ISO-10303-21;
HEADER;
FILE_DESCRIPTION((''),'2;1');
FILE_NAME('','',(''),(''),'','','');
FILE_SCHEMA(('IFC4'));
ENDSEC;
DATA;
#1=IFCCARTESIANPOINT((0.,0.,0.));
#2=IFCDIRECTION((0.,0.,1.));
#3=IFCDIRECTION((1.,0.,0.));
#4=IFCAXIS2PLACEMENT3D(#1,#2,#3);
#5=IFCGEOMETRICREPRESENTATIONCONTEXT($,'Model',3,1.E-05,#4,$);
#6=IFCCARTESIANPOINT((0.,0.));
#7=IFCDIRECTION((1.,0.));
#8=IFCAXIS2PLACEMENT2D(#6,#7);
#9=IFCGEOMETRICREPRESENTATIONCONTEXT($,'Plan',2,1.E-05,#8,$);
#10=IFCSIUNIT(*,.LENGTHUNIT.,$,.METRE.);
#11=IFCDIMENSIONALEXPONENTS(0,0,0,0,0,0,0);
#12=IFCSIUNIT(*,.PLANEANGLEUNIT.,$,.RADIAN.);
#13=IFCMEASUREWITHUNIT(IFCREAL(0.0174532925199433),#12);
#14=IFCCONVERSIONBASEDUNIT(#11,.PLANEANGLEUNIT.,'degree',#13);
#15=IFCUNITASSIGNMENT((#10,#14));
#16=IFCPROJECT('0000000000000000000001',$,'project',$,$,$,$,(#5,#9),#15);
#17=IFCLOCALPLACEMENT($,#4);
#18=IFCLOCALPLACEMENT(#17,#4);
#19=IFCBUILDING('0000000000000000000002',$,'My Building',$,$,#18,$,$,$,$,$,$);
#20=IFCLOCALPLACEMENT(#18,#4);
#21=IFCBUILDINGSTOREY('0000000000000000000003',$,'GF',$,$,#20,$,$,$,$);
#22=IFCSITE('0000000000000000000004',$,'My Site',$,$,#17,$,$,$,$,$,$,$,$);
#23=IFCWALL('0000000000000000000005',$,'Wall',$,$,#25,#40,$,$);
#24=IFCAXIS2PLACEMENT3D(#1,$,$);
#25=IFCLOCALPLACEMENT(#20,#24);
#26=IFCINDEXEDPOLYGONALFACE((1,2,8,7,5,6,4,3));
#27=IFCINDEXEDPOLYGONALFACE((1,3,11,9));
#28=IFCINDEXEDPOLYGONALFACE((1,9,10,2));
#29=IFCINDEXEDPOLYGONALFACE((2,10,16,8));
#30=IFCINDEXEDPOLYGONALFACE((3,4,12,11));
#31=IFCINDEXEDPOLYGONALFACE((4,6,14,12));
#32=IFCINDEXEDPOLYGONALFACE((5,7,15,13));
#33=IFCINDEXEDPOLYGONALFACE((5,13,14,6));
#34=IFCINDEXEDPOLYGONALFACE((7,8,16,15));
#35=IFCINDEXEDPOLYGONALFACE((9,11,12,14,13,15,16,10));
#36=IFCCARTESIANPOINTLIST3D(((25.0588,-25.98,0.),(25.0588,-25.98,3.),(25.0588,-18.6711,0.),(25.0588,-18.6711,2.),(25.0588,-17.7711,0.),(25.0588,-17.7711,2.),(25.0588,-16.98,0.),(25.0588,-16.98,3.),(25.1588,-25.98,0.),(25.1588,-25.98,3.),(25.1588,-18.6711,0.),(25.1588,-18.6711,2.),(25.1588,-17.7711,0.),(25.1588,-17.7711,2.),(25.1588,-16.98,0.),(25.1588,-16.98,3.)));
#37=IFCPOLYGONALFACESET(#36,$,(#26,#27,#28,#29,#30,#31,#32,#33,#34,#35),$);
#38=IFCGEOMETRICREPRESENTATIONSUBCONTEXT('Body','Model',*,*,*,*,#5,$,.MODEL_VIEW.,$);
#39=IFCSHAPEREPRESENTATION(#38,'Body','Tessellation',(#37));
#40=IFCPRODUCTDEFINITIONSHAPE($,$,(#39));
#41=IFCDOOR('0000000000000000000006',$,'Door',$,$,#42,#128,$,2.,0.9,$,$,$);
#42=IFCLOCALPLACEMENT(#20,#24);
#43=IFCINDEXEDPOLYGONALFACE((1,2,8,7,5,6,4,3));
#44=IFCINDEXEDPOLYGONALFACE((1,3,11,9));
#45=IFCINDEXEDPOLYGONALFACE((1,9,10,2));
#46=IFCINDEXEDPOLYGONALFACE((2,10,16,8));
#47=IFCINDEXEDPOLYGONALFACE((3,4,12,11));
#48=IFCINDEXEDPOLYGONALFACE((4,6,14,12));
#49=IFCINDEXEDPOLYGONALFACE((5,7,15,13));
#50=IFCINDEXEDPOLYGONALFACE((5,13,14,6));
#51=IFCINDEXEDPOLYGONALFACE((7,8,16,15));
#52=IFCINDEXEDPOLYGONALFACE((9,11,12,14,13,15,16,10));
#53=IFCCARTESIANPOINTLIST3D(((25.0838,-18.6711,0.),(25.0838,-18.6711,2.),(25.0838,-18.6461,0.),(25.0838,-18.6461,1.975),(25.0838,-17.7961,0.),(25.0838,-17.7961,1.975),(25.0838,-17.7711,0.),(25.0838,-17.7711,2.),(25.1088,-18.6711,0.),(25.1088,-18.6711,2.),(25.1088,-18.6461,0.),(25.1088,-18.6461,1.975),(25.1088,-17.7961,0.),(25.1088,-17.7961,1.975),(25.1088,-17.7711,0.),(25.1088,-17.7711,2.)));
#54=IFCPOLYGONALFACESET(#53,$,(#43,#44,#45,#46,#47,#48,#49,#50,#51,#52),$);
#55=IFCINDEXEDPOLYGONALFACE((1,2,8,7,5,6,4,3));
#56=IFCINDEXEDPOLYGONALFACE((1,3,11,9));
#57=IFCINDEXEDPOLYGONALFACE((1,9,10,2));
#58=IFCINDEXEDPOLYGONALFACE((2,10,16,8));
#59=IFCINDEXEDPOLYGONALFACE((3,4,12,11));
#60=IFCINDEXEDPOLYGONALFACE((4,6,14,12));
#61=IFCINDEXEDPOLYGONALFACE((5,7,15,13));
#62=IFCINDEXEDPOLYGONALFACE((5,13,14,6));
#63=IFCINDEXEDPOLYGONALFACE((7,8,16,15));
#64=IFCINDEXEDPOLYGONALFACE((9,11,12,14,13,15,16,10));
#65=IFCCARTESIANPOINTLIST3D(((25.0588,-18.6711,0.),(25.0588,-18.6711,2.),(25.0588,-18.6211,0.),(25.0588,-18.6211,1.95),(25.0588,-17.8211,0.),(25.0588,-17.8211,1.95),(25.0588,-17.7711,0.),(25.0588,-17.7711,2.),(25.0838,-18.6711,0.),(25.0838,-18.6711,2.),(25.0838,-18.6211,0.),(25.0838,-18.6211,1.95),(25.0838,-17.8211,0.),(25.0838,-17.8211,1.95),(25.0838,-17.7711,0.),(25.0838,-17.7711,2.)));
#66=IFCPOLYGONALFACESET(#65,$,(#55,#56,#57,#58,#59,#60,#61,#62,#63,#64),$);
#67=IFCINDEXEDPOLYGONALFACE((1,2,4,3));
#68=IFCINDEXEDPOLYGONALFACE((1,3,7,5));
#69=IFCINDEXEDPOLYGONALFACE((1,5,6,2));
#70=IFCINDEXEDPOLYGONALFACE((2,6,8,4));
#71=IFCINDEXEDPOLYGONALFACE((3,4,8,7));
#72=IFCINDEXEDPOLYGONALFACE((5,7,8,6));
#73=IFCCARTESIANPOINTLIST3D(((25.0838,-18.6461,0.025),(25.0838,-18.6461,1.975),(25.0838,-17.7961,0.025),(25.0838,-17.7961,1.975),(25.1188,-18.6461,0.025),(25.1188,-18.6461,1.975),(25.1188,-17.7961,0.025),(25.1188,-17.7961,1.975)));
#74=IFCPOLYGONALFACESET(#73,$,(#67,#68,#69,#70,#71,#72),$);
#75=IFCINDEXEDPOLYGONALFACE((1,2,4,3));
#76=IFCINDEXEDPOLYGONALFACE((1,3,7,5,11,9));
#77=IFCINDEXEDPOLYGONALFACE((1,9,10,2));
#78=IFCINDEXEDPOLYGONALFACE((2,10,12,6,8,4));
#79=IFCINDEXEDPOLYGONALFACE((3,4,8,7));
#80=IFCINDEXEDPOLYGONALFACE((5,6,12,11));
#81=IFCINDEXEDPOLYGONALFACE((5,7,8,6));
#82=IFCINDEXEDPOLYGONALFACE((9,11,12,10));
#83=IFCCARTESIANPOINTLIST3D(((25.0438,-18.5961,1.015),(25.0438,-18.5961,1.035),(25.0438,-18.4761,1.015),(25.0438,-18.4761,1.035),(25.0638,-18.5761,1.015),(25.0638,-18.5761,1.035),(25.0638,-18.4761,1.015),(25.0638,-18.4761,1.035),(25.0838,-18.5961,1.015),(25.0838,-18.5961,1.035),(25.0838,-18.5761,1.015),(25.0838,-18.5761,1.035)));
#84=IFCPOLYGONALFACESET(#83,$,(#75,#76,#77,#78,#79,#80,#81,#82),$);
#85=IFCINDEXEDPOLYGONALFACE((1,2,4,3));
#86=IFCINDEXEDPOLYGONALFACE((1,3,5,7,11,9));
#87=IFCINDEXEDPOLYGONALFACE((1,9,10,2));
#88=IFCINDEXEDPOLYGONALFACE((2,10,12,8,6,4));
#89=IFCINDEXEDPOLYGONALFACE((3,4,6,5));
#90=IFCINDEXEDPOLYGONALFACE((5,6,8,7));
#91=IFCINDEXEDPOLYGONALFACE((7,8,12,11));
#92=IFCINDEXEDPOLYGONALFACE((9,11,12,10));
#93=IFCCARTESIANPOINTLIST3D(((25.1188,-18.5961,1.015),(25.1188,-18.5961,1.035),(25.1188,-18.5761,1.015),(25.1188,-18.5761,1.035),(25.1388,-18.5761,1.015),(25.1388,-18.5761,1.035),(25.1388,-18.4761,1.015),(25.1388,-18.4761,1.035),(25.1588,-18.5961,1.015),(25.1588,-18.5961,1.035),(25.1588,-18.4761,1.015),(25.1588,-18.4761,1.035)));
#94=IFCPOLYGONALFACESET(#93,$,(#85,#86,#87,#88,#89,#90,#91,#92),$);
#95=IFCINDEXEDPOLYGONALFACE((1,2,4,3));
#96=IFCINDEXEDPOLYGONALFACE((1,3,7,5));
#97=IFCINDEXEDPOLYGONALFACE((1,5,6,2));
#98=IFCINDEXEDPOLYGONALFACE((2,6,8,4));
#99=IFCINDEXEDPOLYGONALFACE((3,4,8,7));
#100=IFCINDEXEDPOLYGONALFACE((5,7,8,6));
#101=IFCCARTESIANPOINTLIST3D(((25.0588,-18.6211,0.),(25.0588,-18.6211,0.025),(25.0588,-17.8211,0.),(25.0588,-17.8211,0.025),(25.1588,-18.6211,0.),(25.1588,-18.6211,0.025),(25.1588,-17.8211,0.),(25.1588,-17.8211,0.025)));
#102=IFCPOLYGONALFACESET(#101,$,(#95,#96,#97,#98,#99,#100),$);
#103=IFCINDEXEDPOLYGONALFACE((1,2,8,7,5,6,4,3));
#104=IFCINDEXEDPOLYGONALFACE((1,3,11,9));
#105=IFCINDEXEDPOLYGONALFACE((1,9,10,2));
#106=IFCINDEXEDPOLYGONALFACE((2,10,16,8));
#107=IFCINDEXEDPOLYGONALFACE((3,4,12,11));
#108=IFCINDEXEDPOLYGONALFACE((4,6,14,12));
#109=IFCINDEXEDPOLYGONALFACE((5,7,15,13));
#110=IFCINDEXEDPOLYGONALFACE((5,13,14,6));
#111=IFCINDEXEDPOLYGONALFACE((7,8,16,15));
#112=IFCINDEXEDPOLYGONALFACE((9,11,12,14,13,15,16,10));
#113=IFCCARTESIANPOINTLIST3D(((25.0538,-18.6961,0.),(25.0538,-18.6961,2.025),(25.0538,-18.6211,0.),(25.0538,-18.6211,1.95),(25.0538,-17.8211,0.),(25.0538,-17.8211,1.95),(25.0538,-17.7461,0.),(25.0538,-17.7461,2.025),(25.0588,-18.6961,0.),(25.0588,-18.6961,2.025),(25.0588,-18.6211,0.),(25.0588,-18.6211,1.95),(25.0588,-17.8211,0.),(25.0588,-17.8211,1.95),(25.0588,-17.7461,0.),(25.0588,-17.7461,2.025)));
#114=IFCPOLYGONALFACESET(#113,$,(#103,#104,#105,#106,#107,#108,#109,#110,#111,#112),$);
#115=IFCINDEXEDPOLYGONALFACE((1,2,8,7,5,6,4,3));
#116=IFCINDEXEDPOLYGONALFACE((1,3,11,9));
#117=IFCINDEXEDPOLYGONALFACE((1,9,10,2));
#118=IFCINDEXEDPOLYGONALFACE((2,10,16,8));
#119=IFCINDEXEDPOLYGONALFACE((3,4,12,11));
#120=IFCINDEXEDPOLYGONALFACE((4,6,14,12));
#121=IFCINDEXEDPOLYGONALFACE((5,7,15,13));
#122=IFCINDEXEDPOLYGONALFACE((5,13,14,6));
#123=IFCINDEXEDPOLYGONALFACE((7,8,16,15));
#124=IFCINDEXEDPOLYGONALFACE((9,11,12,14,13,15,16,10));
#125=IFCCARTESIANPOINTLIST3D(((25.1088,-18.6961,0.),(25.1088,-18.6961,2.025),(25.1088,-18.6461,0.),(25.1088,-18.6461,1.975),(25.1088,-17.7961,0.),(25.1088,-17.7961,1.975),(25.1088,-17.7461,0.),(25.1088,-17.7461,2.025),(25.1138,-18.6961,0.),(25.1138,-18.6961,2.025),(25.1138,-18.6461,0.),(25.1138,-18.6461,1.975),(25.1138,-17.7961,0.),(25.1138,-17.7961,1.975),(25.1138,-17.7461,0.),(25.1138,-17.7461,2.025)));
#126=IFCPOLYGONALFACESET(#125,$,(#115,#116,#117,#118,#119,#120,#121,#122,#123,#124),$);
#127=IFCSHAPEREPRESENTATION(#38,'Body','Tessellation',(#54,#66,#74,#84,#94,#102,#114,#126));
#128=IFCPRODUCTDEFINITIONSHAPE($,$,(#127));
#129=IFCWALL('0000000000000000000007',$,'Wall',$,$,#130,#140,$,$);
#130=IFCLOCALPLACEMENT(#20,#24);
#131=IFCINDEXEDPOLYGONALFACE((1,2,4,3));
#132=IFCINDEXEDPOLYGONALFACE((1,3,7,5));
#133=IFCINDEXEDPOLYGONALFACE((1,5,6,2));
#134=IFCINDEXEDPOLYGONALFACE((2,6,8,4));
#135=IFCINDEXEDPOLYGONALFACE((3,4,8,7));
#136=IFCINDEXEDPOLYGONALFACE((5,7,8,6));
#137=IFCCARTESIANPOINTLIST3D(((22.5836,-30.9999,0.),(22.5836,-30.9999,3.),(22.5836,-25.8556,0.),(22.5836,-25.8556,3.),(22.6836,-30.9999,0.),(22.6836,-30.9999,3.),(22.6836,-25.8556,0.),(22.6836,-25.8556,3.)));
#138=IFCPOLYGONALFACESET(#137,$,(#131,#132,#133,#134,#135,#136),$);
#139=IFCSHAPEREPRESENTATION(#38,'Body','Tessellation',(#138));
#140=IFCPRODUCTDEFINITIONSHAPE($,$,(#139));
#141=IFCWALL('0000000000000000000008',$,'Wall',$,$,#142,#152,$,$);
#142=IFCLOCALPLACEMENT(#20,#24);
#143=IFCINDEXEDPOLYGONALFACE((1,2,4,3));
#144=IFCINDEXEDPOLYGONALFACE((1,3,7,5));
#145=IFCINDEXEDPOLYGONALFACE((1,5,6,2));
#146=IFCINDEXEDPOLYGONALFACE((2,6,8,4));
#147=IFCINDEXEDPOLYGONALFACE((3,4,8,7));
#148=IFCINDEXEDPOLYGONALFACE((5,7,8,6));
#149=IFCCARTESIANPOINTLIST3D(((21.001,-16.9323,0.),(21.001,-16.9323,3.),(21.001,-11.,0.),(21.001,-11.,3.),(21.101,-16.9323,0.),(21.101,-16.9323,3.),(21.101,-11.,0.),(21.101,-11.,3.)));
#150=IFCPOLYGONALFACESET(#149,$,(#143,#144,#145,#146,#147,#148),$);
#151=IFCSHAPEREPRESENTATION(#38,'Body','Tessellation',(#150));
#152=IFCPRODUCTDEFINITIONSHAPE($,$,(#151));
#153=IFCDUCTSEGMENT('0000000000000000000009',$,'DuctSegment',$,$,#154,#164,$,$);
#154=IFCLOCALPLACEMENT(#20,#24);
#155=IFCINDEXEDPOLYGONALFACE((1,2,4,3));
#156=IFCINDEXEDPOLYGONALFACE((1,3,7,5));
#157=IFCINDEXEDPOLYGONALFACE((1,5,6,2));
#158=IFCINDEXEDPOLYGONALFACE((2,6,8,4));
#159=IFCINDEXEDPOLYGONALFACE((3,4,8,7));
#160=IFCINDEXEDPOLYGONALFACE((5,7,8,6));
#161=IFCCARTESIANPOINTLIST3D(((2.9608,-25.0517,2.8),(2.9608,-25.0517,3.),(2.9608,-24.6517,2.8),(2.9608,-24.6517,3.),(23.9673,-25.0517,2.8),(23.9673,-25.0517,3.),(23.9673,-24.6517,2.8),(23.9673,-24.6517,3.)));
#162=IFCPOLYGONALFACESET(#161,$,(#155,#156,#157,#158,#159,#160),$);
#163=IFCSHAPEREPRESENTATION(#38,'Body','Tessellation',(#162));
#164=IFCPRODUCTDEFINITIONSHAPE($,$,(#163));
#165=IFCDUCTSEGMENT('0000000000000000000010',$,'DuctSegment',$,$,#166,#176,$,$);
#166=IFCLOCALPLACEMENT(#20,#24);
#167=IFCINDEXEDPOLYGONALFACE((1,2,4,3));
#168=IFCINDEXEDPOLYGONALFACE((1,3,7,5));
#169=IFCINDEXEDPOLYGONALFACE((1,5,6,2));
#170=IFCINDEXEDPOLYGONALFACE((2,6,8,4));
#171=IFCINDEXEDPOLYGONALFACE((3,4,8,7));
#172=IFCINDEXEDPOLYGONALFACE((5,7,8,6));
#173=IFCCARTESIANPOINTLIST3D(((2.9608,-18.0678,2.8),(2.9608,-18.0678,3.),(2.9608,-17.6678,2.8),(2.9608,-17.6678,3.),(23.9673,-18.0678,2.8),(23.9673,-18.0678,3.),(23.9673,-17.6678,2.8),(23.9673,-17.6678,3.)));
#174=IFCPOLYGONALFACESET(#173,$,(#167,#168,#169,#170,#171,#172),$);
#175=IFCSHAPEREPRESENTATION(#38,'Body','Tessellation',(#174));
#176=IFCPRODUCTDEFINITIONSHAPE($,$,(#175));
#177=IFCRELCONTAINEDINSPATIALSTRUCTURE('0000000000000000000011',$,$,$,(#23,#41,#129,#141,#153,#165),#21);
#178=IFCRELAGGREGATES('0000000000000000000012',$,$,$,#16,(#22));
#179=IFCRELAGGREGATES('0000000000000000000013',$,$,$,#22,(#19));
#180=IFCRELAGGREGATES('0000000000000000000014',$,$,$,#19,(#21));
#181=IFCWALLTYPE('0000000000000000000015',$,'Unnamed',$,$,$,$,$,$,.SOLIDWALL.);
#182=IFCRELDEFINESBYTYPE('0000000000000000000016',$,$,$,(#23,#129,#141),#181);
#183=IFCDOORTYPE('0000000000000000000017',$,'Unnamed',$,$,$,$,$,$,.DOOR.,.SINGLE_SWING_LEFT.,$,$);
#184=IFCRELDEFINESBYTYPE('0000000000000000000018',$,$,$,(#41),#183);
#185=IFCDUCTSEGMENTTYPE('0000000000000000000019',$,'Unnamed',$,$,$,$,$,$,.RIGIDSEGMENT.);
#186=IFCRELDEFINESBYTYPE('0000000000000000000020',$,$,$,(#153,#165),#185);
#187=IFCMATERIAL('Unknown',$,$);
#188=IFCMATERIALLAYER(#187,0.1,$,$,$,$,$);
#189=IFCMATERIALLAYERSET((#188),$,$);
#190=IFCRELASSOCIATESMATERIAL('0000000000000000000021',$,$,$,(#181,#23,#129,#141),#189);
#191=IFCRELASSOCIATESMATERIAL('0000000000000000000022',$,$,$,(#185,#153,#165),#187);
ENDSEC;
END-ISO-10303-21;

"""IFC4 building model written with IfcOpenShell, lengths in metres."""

from ifc_helpers import new_model, entity, si_unit, converted_unit, frame, origin_with_axes, origin_2d_with_axis, place, context, subcontext, project, spatial, line, indexed_curve, rectangle, outline, extrude, shape, source, transform, mapped, material, layer, layer_set, layer_usage, material_profile, profile_set, profile_usage, type_object, type_shapes, element, fill, save


model = new_model("IFC4")

# Units and contexts
model_context = context("Model", 3, precision=1e-05, world=origin_with_axes())
plan_context = context("Plan", 2, precision=1e-05, world=origin_2d_with_axis())
body_context_1 = subcontext(model_context, "Body", "Model", "MODEL_VIEW")
body_context_2 = subcontext(plan_context, "Body", "Plan", "PLAN_VIEW")
ifc_project = project(units=[si_unit("LENGTHUNIT", "METRE"), converted_unit("PLANEANGLEUNIT", "degree", entity("IfcReal", 0.0174532925199433), si_unit("PLANEANGLEUNIT", "RADIAN"), dimensions=[0, 0, 0, 0, 0, 0, 0])], contexts=[model_context, plan_context])

# Site, building, storey
site_placement = place(None, origin_with_axes())
site = spatial("IfcSite", under=ifc_project, at=site_placement, Name="My Site")
building_placement = place(site_placement, origin_with_axes())
building = spatial("IfcBuilding", under=site, at=building_placement, Name="My Building")
storey_placement = place(building_placement, origin_with_axes())
storey = spatial("IfcBuildingStorey", under=building, at=storey_placement, Name="GF")

# Shared definitions
ifc_material = material(Name="Unknown")
ifc_layer = layer(ifc_material, 0.1)
ifc_layer_set = layer_set([ifc_layer])
wall_type = type_object("IfcWallType", Name="Unnamed", PredefinedType="SOLIDWALL", material=ifc_layer_set)

# Shared definitions
shared_shape_1 = source(origin_with_axes(), body_context_1, "Body", "SweptSolid", [
    extrude(outline(indexed_curve([(0.0, 0.0), (0.9, 0.0), (0.9, 2.0), (0.0, 2.0)], segments=[line(1, 2, 3, 4, 1)])), frame((0.0, -0.6, 0.0), z_axis=(0.0, -1.0, 0.0), x_axis=(1.0, 0.0, 0.0)), (0.0, 0.0, -1.0), 1.2),
])
door_type = type_object("IfcDoorType", Name="Unnamed", OperationType="SINGLE_SWING_LEFT", PredefinedType="DOOR")
shared_shape_2 = source(origin_with_axes(), body_context_1, "Body", "SweptSolid", [
    extrude(outline(indexed_curve([(0.0, 0.0), (0.0, 2.0), (0.9, 2.0), (0.9, 0.0), (0.875, 0.0), (0.875, 1.975), (0.025, 1.975), (0.025, 0.0)], segments=[line(1, 2, 3, 4, 5, 6, 7, 8, 1)])), frame((0.0, 0.025, 0.0), z_axis=(0.0, -1.0, 0.0), x_axis=(1.0, 0.0, 0.0)), (0.0, 0.0, -1.0), 0.025),
    extrude(outline(indexed_curve([(0.0, 0.0), (0.0, 2.0), (0.9, 2.0), (0.9, 0.0), (0.85, 0.0), (0.85, 1.95), (0.05, 1.95), (0.05, 0.0)], segments=[line(1, 2, 3, 4, 5, 6, 7, 8, 1)])), frame((0.0, 0.0, 0.0), z_axis=(0.0, -1.0, 0.0), x_axis=(1.0, 0.0, 0.0)), (0.0, 0.0, -1.0), 0.025),
    extrude(outline(indexed_curve([(0.0, 0.0), (0.85, 0.0), (0.85, 0.035), (0.0, 0.035)], segments=[line(1, 2, 3, 4, 1)])), frame((0.025, 0.025, 0.025), z_axis=(0.0, 0.0, 1.0), x_axis=(1.0, 0.0, 0.0)), (0.0, 0.0, 1.0), 1.95),
    extrude(outline(indexed_curve([(0.0, 0.0), (0.0, -0.04), (-0.12, -0.04), (-0.12, -0.02), (-0.02, -0.02), (-0.02, 0.0)], segments=[line(1, 2, 3, 4, 5, 6, 1)])), frame((0.825, 0.025, 1.015), z_axis=(0.0, 0.0, 1.0), x_axis=(1.0, 0.0, 0.0)), (0.0, 0.0, 1.0), 0.02),
    extrude(outline(indexed_curve([(0.0, 0.0), (0.0, 0.04), (-0.12, 0.04), (-0.12, 0.02), (-0.02, 0.02), (-0.02, 0.0)], segments=[line(1, 2, 3, 4, 5, 6, 1)])), frame((0.825, 0.06, 1.015), z_axis=(0.0, 0.0, 1.0), x_axis=(1.0, 0.0, 0.0)), (0.0, 0.0, 1.0), 0.02),
    extrude(outline(indexed_curve([(0.0, 0.0), (0.8, 0.0), (0.8, 0.1), (0.0, 0.1)], segments=[line(1, 2, 3, 4, 1)])), frame((0.05, 0.0, 0.0), z_axis=(0.0, 0.0, 1.0), x_axis=(1.0, 0.0, 0.0)), (0.0, 0.0, 1.0), 0.025),
    extrude(outline(indexed_curve([(0.0, 0.0), (0.0, 2.025), (0.95, 2.025), (0.95, 0.0), (0.875, 0.0), (0.875, 1.95), (0.075, 1.95), (0.075, 0.0)], segments=[line(1, 2, 3, 4, 5, 6, 7, 8, 1)])), frame((-0.025, -0.005, 0.0), z_axis=(0.0, -1.0, 0.0), x_axis=(1.0, 0.0, 0.0)), (0.0, 0.0, -1.0), 0.005),
    extrude(outline(indexed_curve([(0.0, 0.0), (0.0, 2.025), (0.95, 2.025), (0.95, 0.0), (0.9, 0.0), (0.9, 1.975), (0.05, 1.975), (0.05, 0.0)], segments=[line(1, 2, 3, 4, 5, 6, 7, 8, 1)])), frame((-0.025, 0.05, 0.0), z_axis=(0.0, -1.0, 0.0), x_axis=(1.0, 0.0, 0.0)), (0.0, 0.0, -1.0), 0.005),
])
shared_shape_3 = source(origin_with_axes(), body_context_2, "Body", "Curve2D", [
    entity("IfcIndexedPolyCurve", entity("IfcCartesianPointList2D", [[0.0, 0.0], [0.0, 0.05], [0.025, 0.05], [0.025, 0.025], [0.05, 0.025], [0.05, 0.0]]), [entity("IfcLineIndex", [1, 2, 3, 4, 5, 6, 1])]),
    entity("IfcIndexedPolyCurve", entity("IfcCartesianPointList2D", [[0.9, 0.0], [0.9, 0.05], [0.875, 0.05], [0.875, 0.025], [0.85, 0.025], [0.85, 0.0]]), [entity("IfcLineIndex", [1, 2, 3, 4, 5, 6, 1])]),
    entity("IfcTrimmedCurve", entity("IfcEllipse", entity("IfcAxis2Placement2D", entity("IfcCartesianPoint", [0.06, 0.05]), entity("IfcDirection", [1.0, 0.0])), 0.815, 0.85), [entity("IfcCartesianPoint", [0.875, 0.05])], [entity("IfcCartesianPoint", [0.06, 0.9])], True, "CARTESIAN"),
    entity("IfcIndexedPolyCurve", entity("IfcCartesianPointList2D", [[0.025, 0.05], [0.06, 0.05], [0.06, 0.9], [0.025, 0.9]]), [entity("IfcLineIndex", [1, 2, 3, 4, 1])]),
])
type_shapes(door_type, [shared_shape_2, shared_shape_3])

# Wall, opening, door
ifc_layer_usage_1 = layer_usage(ifc_layer_set, "AXIS2", "POSITIVE", 0.0)
wall_1_placement = place(storey_placement, frame((25.0588, -16.98, 0.0), z_axis=(0.0, 0.0, 1.0), x_axis=(0.0, -1.0, 0.0)))
wall_1 = element("IfcWall", 1, at=wall_1_placement, inside=storey, type_object=wall_type, material=ifc_layer_usage_1, Name="Wall", context=body_context_1, shape_type="SweptSolid", body=[
    extrude(outline(indexed_curve([(0.0, 0.0), (0.0, 0.1), (9.0, 0.1), (9.0, 0.0)], segments=[line(1, 2, 3, 4, 1)])), origin_with_axes(), (0.0, 0.0, 1.0), 3.0),
])
opening_1_placement = place(wall_1_placement, frame((0.7911, 0.0, 0.0), z_axis=(0.0, 0.0, 1.0), x_axis=(1.0, 0.0, 0.0)))
opening_1 = element("IfcOpeningElement", 2, at=opening_1_placement, cuts=wall_1, PredefinedType="OPENING", context=body_context_1, shape_type="MappedRepresentation", body=[
    mapped(shared_shape_1, transform((0.0, 0.0, 0.0), x_axis=(1.0, 0.0, 0.0), y_axis=(0.0, 1.0, 0.0), z_axis=(0.0, 0.0, 1.0), scale=1.0)),
])
door_1_placement = place(opening_1_placement, frame((0.0, 0.0, 0.0), z_axis=(0.0, 0.0, 1.0), x_axis=(1.0, 0.0, 0.0)))
door_1 = element("IfcDoor", 3, at=door_1_placement, inside=storey, type_object=door_type, Name="Door", OverallHeight=2.0, OverallWidth=0.9, shapes=[
    shape(body_context_1, "Body", "MappedRepresentation", [mapped(shared_shape_2, transform((0.0, 0.0, 0.0), x_axis=(1.0, 0.0, 0.0), y_axis=(0.0, 1.0, 0.0), z_axis=(0.0, 0.0, 1.0), scale=1.0))]),
    shape(body_context_2, "Body", "MappedRepresentation", [mapped(shared_shape_3, transform((0.0, 0.0, 0.0), x_axis=(1.0, 0.0, 0.0), y_axis=(0.0, 1.0, 0.0), z_axis=(0.0, 0.0, 1.0), scale=1.0))]),
])
fill(opening_1, door_1)

# Walls
ifc_layer_usage_2 = layer_usage(ifc_layer_set, "AXIS2", "POSITIVE", 0.0)
wall_2_placement = place(storey_placement, frame((22.5836, -25.8556, 0.0), z_axis=(0.0, 0.0, 1.0), x_axis=(0.0, -1.0, 0.0)))
element("IfcWall", 4, at=wall_2_placement, inside=storey, type_object=wall_type, material=ifc_layer_usage_2, Name="Wall", context=body_context_1, shape_type="SweptSolid", body=[
    extrude(outline(indexed_curve([(0.0, 0.0), (0.0, 0.1), (5.1443, 0.1), (5.1443, 0.0)], segments=[line(1, 2, 3, 4, 1)])), origin_with_axes(), (0.0, 0.0, 1.0), 3.0),
])
ifc_layer_usage_3 = layer_usage(ifc_layer_set, "AXIS2", "POSITIVE", 0.0)
wall_3_placement = place(storey_placement, frame((21.101, -16.9323, 0.0), z_axis=(0.0, 0.0, 1.0), x_axis=(0.0, 1.0, 0.0)))
element("IfcWall", 5, at=wall_3_placement, inside=storey, type_object=wall_type, material=ifc_layer_usage_3, Name="Wall", context=body_context_1, shape_type="SweptSolid", body=[
    extrude(outline(indexed_curve([(0.0, 0.0), (0.0, 0.1), (5.9323, 0.1), (5.9323, 0.0)], segments=[line(1, 2, 3, 4, 1)])), origin_with_axes(), (0.0, 0.0, 1.0), 3.0),
])

# Duct segments
ifc_material_profile_1 = material_profile(ifc_material, rectangle(XDim=0.4, YDim=0.2))
ifc_profile_set_1 = profile_set([ifc_material_profile_1])
ifc_profile_usage_1 = profile_usage(ifc_profile_set_1, cardinal=5)
duct_segment_type = type_object("IfcDuctSegmentType", Name="Unnamed", PredefinedType="RIGIDSEGMENT", material=ifc_profile_set_1)
duct_segment_1_placement = place(storey_placement, frame((23.9673, -24.8517, 2.9), z_axis=(-1.0, 0.0, 0.0), x_axis=(0.0, -1.0, 0.0)))
element("IfcDuctSegment", 6, at=duct_segment_1_placement, inside=storey, type_object=duct_segment_type, material=ifc_profile_usage_1, Name="DuctSegment", context=body_context_1, shape_type="SweptSolid", body=[
    extrude(rectangle(XDim=0.4, YDim=0.2), origin_with_axes(), (0.0, 0.0, 1.0), 21.0065),
])
ifc_profile_usage_2 = profile_usage(ifc_profile_set_1, cardinal=5)
duct_segment_2_placement = place(storey_placement, frame((23.9673, -17.8678, 2.9), z_axis=(-1.0, 0.0, 0.0), x_axis=(0.0, -1.0, 0.0)))
element("IfcDuctSegment", 7, at=duct_segment_2_placement, inside=storey, type_object=duct_segment_type, material=ifc_profile_usage_2, Name="DuctSegment", context=body_context_1, shape_type="SweptSolid", body=[
    extrude(rectangle(XDim=0.4, YDim=0.2), origin_with_axes(), (0.0, 0.0, 1.0), 21.0065),
])

save(model, "model.ifc")
